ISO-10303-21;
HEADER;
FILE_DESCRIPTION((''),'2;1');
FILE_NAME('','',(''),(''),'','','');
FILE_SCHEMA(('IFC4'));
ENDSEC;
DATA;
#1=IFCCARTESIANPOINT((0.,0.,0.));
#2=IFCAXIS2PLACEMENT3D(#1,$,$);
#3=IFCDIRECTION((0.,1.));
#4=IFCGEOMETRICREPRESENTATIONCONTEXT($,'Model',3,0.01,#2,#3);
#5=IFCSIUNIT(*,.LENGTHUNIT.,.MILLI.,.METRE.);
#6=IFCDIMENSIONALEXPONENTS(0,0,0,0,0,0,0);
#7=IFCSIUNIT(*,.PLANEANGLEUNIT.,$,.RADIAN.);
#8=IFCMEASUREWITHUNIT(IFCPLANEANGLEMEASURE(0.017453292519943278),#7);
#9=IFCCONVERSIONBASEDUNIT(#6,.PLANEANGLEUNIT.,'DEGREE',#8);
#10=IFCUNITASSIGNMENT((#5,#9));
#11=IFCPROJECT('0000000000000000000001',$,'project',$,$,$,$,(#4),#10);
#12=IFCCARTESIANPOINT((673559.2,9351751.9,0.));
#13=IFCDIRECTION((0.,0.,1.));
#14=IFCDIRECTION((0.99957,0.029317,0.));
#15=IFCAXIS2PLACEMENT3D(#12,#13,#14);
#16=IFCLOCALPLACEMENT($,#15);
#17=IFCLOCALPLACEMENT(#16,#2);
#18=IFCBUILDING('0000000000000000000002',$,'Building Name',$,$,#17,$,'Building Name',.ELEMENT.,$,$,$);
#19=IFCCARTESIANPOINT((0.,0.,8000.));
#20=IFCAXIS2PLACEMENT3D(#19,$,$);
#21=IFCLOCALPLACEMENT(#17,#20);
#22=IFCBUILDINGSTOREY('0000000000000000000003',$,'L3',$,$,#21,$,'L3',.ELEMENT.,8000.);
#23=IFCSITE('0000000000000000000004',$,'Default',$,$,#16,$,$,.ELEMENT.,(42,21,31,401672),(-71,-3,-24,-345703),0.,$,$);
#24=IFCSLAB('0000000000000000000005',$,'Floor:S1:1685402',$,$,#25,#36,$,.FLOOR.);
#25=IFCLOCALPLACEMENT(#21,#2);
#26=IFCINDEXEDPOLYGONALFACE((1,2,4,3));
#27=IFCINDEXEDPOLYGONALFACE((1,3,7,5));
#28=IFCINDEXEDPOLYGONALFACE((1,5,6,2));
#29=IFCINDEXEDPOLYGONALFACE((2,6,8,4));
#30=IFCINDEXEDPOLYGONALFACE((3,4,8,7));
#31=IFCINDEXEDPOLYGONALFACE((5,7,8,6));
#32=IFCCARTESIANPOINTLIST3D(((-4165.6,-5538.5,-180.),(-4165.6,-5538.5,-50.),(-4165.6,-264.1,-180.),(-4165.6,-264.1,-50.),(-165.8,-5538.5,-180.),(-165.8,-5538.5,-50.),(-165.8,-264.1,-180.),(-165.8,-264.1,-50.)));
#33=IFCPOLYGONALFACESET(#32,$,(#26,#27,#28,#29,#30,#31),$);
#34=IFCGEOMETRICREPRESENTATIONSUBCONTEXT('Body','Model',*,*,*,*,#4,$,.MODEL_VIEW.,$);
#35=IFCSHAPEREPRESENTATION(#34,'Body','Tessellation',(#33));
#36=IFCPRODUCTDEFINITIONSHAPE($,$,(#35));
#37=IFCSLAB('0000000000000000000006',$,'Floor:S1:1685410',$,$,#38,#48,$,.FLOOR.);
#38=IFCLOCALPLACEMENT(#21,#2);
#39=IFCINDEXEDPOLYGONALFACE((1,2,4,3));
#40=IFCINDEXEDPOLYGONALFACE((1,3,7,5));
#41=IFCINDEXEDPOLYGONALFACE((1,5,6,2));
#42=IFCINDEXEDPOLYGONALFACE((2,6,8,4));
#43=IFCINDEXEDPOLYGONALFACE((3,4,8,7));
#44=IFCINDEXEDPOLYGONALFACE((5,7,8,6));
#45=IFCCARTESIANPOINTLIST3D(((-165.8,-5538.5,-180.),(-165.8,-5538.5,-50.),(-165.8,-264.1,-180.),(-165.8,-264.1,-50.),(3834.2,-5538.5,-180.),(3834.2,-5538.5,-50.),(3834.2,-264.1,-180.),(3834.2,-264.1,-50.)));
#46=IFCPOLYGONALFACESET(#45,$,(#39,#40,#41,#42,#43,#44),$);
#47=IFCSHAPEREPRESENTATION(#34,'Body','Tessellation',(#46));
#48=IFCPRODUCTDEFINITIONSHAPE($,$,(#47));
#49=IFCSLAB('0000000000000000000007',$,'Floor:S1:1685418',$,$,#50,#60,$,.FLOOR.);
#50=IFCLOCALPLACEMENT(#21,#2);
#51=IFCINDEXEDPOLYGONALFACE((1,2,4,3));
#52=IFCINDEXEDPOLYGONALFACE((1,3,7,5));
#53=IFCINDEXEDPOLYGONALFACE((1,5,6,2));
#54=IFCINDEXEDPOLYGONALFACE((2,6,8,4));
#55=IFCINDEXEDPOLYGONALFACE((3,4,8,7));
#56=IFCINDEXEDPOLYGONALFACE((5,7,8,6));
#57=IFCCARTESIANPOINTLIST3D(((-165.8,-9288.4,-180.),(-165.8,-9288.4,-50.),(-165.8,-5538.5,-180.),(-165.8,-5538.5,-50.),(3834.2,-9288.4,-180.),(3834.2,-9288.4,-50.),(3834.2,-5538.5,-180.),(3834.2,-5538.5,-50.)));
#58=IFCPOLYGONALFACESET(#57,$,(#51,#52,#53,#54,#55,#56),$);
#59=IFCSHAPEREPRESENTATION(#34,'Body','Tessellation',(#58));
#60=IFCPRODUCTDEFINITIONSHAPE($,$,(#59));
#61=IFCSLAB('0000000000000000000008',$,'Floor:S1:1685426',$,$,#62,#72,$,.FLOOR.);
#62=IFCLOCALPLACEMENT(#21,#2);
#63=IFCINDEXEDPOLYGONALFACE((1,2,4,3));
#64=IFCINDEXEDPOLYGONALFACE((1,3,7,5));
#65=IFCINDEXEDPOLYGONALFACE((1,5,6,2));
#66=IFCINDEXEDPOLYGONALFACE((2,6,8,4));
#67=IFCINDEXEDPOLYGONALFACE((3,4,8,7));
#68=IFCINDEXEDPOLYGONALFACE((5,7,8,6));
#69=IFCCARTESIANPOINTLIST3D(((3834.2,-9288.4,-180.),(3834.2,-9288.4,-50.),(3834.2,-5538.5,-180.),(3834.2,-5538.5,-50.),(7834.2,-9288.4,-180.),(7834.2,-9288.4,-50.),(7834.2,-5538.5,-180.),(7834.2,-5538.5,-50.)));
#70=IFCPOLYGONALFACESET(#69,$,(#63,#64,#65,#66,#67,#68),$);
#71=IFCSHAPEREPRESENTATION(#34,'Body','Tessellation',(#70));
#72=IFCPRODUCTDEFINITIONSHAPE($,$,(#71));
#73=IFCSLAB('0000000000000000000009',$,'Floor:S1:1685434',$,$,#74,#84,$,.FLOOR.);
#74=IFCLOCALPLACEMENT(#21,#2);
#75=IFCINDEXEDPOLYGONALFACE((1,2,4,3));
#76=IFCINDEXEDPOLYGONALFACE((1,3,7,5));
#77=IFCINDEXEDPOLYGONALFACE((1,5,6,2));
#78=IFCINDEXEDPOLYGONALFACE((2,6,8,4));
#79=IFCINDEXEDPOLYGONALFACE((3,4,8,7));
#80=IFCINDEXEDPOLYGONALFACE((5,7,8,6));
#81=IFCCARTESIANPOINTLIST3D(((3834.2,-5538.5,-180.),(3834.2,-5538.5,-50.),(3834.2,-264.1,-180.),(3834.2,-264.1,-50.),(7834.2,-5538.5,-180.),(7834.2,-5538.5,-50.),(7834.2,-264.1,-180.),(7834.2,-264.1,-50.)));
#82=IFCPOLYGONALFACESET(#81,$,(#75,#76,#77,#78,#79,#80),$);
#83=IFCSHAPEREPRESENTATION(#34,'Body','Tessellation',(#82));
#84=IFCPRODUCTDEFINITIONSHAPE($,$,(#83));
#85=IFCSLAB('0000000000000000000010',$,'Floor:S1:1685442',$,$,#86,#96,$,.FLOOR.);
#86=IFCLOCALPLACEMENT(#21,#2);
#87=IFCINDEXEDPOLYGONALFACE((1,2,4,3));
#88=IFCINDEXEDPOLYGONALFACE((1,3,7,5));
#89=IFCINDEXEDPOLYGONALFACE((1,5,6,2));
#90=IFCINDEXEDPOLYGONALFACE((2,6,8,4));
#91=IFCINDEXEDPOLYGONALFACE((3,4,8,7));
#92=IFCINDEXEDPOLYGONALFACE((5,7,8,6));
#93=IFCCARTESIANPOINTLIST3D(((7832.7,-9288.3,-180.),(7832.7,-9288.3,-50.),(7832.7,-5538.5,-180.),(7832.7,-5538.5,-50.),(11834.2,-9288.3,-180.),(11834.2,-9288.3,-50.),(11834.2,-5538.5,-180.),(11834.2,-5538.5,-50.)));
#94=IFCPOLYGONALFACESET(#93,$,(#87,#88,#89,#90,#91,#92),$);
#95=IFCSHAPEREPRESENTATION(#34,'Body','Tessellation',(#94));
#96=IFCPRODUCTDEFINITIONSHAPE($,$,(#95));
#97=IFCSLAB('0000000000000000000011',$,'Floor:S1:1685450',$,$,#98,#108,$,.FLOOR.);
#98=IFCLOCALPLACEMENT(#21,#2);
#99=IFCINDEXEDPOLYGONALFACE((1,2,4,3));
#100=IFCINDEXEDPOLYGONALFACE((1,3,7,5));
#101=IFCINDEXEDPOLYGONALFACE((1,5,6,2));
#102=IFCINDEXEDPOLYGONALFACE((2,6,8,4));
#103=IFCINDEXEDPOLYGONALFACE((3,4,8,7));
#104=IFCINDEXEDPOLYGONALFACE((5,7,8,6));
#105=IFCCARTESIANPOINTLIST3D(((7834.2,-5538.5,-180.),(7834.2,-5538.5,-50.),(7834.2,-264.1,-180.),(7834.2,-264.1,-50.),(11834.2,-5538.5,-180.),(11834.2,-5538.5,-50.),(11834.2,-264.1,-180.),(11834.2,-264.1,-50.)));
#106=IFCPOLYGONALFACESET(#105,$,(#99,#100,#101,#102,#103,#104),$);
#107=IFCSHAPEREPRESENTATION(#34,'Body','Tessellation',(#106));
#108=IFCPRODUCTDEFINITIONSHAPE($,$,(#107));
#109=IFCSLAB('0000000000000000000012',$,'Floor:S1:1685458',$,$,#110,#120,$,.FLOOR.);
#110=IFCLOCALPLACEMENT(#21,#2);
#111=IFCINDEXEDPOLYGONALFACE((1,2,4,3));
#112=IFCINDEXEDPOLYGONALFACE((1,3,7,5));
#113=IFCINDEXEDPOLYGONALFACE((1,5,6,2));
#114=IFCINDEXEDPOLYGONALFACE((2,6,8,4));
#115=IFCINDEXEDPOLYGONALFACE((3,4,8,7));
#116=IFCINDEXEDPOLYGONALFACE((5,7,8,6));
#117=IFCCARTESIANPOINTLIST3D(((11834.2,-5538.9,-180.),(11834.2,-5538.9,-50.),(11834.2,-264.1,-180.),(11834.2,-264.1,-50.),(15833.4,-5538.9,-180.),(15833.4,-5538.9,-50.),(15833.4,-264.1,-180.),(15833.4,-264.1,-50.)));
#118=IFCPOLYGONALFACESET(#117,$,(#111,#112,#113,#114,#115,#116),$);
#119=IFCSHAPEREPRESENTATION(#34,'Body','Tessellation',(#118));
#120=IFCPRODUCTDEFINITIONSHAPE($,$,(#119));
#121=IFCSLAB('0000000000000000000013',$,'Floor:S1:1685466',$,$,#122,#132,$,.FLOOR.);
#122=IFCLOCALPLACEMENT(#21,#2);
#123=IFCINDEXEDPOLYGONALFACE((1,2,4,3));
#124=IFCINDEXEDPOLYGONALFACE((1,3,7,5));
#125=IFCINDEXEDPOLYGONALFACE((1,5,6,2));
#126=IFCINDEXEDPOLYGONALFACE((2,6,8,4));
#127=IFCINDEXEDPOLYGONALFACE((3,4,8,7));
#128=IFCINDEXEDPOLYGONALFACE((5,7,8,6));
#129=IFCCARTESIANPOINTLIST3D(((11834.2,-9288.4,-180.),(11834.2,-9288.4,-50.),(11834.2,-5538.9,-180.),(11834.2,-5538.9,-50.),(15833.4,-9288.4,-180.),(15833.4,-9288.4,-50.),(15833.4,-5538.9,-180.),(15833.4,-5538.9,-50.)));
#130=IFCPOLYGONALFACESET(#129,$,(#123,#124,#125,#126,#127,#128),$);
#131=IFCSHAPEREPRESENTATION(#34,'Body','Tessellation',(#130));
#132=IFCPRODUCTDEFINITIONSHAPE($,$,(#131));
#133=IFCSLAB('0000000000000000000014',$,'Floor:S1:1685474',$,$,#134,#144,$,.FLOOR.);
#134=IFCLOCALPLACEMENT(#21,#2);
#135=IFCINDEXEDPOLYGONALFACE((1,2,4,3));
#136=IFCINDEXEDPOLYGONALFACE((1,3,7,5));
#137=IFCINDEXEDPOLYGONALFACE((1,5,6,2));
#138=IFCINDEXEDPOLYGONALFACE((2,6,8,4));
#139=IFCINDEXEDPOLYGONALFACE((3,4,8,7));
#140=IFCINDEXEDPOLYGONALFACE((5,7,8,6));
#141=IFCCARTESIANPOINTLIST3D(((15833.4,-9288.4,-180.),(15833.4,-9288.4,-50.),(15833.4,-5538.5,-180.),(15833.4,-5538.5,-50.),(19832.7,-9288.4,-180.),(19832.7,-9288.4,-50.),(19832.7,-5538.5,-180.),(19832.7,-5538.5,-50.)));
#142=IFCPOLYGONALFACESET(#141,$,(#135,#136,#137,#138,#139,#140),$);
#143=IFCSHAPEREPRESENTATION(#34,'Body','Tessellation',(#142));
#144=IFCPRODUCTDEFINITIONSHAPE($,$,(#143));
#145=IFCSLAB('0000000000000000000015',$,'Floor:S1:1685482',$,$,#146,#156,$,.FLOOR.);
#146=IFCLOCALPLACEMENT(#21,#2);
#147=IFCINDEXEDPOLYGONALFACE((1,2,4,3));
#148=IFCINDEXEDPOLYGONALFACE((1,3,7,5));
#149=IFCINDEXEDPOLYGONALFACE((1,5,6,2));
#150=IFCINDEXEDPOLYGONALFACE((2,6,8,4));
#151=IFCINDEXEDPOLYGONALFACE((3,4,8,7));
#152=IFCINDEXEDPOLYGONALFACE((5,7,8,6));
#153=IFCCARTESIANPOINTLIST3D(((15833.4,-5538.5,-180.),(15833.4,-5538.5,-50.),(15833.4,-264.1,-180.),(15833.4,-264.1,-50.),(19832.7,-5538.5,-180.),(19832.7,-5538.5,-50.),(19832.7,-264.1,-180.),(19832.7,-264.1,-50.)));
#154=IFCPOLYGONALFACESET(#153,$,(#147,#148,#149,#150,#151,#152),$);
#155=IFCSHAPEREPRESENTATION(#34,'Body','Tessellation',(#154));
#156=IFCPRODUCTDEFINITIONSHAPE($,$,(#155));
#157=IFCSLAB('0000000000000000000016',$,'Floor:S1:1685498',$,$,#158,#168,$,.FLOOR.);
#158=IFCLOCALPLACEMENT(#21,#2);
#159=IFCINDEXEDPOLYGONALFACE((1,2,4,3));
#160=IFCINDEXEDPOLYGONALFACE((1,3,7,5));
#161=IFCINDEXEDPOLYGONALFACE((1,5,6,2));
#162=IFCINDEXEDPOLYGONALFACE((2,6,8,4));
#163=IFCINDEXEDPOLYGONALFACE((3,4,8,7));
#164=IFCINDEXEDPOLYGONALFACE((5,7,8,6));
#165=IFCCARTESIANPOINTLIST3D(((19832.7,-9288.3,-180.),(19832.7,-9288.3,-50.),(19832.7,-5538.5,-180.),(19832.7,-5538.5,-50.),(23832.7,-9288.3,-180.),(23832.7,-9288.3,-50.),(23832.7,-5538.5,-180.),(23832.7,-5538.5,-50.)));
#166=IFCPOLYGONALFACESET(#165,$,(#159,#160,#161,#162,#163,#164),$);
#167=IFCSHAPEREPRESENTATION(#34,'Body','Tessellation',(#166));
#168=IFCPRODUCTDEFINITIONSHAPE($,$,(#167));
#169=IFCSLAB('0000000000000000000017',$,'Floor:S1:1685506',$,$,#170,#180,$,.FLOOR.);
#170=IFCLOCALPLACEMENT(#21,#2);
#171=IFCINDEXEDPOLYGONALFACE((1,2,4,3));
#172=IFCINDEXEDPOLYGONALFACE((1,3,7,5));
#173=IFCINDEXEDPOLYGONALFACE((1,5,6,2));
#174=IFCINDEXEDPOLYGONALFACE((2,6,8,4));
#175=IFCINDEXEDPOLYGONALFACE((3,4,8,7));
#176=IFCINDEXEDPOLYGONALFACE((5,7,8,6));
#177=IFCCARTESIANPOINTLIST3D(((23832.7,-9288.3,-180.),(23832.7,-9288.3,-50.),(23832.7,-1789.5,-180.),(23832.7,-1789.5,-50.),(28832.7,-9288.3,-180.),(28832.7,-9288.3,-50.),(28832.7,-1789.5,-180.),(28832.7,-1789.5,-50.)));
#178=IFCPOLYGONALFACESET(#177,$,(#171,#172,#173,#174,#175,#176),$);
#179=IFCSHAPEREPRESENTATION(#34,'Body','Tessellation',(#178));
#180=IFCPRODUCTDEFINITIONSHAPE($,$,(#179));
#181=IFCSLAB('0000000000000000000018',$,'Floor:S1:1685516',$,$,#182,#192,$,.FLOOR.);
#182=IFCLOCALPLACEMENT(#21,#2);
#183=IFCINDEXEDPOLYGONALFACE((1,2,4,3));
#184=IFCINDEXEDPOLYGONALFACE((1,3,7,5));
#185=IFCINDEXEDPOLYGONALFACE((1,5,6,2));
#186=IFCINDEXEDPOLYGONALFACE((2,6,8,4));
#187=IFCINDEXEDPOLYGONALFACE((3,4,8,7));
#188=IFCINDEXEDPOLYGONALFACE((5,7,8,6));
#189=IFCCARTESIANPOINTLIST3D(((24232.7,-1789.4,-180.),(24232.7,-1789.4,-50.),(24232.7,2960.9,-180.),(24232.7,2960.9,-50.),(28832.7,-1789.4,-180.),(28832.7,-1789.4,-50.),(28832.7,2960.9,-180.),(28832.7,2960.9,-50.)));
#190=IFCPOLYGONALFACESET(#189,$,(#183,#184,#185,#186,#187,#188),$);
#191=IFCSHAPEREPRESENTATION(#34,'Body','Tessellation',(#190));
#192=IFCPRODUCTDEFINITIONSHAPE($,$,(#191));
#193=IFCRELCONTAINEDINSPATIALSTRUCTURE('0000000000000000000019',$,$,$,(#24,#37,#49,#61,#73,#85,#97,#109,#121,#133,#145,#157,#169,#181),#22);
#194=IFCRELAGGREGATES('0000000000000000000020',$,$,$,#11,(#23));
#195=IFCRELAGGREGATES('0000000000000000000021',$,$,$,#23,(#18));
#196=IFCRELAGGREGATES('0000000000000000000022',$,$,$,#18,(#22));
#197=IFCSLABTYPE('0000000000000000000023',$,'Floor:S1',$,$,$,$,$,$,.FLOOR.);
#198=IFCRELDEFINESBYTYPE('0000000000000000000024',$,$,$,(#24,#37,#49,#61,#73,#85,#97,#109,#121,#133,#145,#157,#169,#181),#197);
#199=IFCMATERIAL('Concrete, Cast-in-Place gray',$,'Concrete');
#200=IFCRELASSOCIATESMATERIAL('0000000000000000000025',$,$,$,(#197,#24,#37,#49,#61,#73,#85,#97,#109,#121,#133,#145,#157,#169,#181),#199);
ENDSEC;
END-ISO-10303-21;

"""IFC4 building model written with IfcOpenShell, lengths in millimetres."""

from ifc_helpers import new_model, entity, si_unit, converted_unit, direction, frame, origin, place, context, subcontext, project, spatial, indexed_curve, outline, extrude, material, type_object, element, save


model = new_model("IFC4")

# Units and contexts
model_context = context("Model", 3, precision=0.01, world=origin(), true_north=direction((0.0, 1.0)))
body_context = subcontext(model_context, "Body", "Model", "MODEL_VIEW")
ifc_project = project(units=[si_unit("LENGTHUNIT", "METRE", prefix="MILLI"), converted_unit("PLANEANGLEUNIT", "DEGREE", entity("IfcPlaneAngleMeasure", 0.017453292519943278), si_unit("PLANEANGLEUNIT", "RADIAN"), dimensions=[0, 0, 0, 0, 0, 0, 0])], contexts=[model_context])

# Site, building, storey
site_placement = place(None, frame((673559.2, 9351751.9, 0.0), z_axis=(0.0, 0.0, 1.0), x_axis=(0.99957, 0.029317, 0.0)))
site = spatial("IfcSite", under=ifc_project, at=site_placement, Name="Default", CompositionType="ELEMENT", RefLatitude=(42, 21, 31, 401672), RefLongitude=(-71, -3, -24, -345703), RefElevation=0.0)
building_placement = place(site_placement, origin())
building = spatial("IfcBuilding", under=site, at=building_placement, Name="Building Name", LongName="Building Name", CompositionType="ELEMENT")
storey_placement = place(building_placement, frame((0.0, 0.0, 8000.0)))
storey = spatial("IfcBuildingStorey", under=building, at=storey_placement, Name="L3", LongName="L3", CompositionType="ELEMENT", Elevation=8000.0)

# Shared definitions
ifc_material = material(Name="Concrete, Cast-in-Place gray", Category="Concrete")

# Slabs
slab_type_1 = type_object("IfcSlabType", Name="Floor:S1", PredefinedType="FLOOR", material=ifc_material)
slab_1_placement = place(storey_placement, origin())
element("IfcSlab", 1, at=slab_1_placement, inside=storey, type_object=slab_type_1, material=ifc_material, Name="Floor:S1:1685402", PredefinedType="FLOOR", context=body_context, shape_type="SweptSolid", body=[
    extrude(outline(indexed_curve([(-2637.2, -1999.9), (2637.2, -1999.9), (2637.2, 1999.9), (-2637.2, 1999.9), (-2637.2, -1999.9)], self_intersect=False)), frame((-2165.7, -2901.3, -50.0), z_axis=(0.0, 0.0, -1.0), x_axis=(0.0, 1.0, 0.0)), (0.0, 0.0, 1.0), 130.0),
])
slab_2_placement = place(storey_placement, origin())
element("IfcSlab", 2, at=slab_2_placement, inside=storey, type_object=slab_type_1, material=ifc_material, Name="Floor:S1:1685410", PredefinedType="FLOOR", context=body_context, shape_type="SweptSolid", body=[
    extrude(outline(indexed_curve([(-2637.2, -2000.0), (2637.2, -2000.0), (2637.2, 2000.0), (-2637.2, 2000.0), (-2637.2, -2000.0)], self_intersect=False)), frame((1834.2, -2901.3, -50.0), z_axis=(0.0, 0.0, -1.0), x_axis=(0.0, 1.0, 0.0)), (0.0, 0.0, 1.0), 130.0),
])
slab_3_placement = place(storey_placement, origin())
element("IfcSlab", 3, at=slab_3_placement, inside=storey, type_object=slab_type_1, material=ifc_material, Name="Floor:S1:1685418", PredefinedType="FLOOR", context=body_context, shape_type="SweptSolid", body=[
    extrude(outline(indexed_curve([(-1874.9, -2000.0), (1874.9, -2000.0), (1874.9, 2000.0), (-1874.9, 2000.0), (-1874.9, -2000.0)], self_intersect=False)), frame((1834.2, -7413.5, -50.0), z_axis=(0.0, 0.0, -1.0), x_axis=(0.0, 1.0, 0.0)), (0.0, 0.0, 1.0), 130.0),
])
slab_4_placement = place(storey_placement, origin())
element("IfcSlab", 4, at=slab_4_placement, inside=storey, type_object=slab_type_1, material=ifc_material, Name="Floor:S1:1685426", PredefinedType="FLOOR", context=body_context, shape_type="SweptSolid", body=[
    extrude(outline(indexed_curve([(-1874.9, -2000.0), (1874.9, -2000.0), (1874.9, 2000.0), (-1874.9, 2000.0), (-1874.9, -2000.0)], self_intersect=False)), frame((5834.2, -7413.5, -50.0), z_axis=(0.0, 0.0, -1.0), x_axis=(0.0, 1.0, 0.0)), (0.0, 0.0, 1.0), 130.0),
])
slab_5_placement = place(storey_placement, origin())
element("IfcSlab", 5, at=slab_5_placement, inside=storey, type_object=slab_type_1, material=ifc_material, Name="Floor:S1:1685434", PredefinedType="FLOOR", context=body_context, shape_type="SweptSolid", body=[
    extrude(outline(indexed_curve([(-2637.2, -2000.0), (2637.2, -2000.0), (2637.2, 2000.0), (-2637.2, 2000.0), (-2637.2, -2000.0)], self_intersect=False)), frame((5834.2, -2901.3, -50.0), z_axis=(0.0, 0.0, -1.0), x_axis=(0.0, 1.0, 0.0)), (0.0, 0.0, 1.0), 130.0),
])
slab_6_placement = place(storey_placement, origin())
element("IfcSlab", 6, at=slab_6_placement, inside=storey, type_object=slab_type_1, material=ifc_material, Name="Floor:S1:1685442", PredefinedType="FLOOR", context=body_context, shape_type="SweptSolid", body=[
    extrude(outline(indexed_curve([(-1874.9, -2000.7), (1874.9, -2000.7), (1874.9, 2000.7), (-1874.9, 2000.7), (-1874.9, -2000.7)], self_intersect=False)), frame((9833.4, -7413.4, -50.0), z_axis=(0.0, 0.0, -1.0), x_axis=(0.0, 1.0, 0.0)), (0.0, 0.0, 1.0), 130.0),
])
slab_7_placement = place(storey_placement, origin())
element("IfcSlab", 7, at=slab_7_placement, inside=storey, type_object=slab_type_1, material=ifc_material, Name="Floor:S1:1685450", PredefinedType="FLOOR", context=body_context, shape_type="SweptSolid", body=[
    extrude(outline(indexed_curve([(-2637.2, -2000.0), (2637.2, -2000.0), (2637.2, 2000.0), (-2637.2, 2000.0), (-2637.2, -2000.0)], self_intersect=False)), frame((9834.2, -2901.3, -50.0), z_axis=(0.0, 0.0, -1.0), x_axis=(0.0, 1.0, 0.0)), (0.0, 0.0, 1.0), 130.0),
])
slab_8_placement = place(storey_placement, origin())
element("IfcSlab", 8, at=slab_8_placement, inside=storey, type_object=slab_type_1, material=ifc_material, Name="Floor:S1:1685458", PredefinedType="FLOOR", context=body_context, shape_type="SweptSolid", body=[
    extrude(outline(indexed_curve([(-2637.4, -1999.6), (2637.4, -1999.6), (2637.4, 1999.6), (-2637.4, 1999.6), (-2637.4, -1999.6)], self_intersect=False)), frame((13833.8, -2901.5, -50.0), z_axis=(0.0, 0.0, -1.0), x_axis=(0.0, 1.0, 0.0)), (0.0, 0.0, 1.0), 130.0),
])
slab_9_placement = place(storey_placement, origin())
element("IfcSlab", 9, at=slab_9_placement, inside=storey, type_object=slab_type_1, material=ifc_material, Name="Floor:S1:1685466", PredefinedType="FLOOR", context=body_context, shape_type="SweptSolid", body=[
    extrude(outline(indexed_curve([(-1874.7, -1999.6), (1874.7, -1999.6), (1874.7, 1999.6), (-1874.7, 1999.6), (-1874.7, -1999.6)], self_intersect=False)), frame((13833.8, -7413.6, -50.0), z_axis=(0.0, 0.0, -1.0), x_axis=(0.0, 1.0, 0.0)), (0.0, 0.0, 1.0), 130.0),
])
slab_10_placement = place(storey_placement, origin())
element("IfcSlab", 10, at=slab_10_placement, inside=storey, type_object=slab_type_1, material=ifc_material, Name="Floor:S1:1685474", PredefinedType="FLOOR", context=body_context, shape_type="SweptSolid", body=[
    extrude(outline(indexed_curve([(-1874.9, -1999.6), (1874.9, -1999.6), (1874.9, 1999.6), (-1874.9, 1999.6), (-1874.9, -1999.6)], self_intersect=False)), frame((17833.0, -7413.5, -50.0), z_axis=(0.0, 0.0, -1.0), x_axis=(0.0, 1.0, 0.0)), (0.0, 0.0, 1.0), 130.0),
])
slab_11_placement = place(storey_placement, origin())
element("IfcSlab", 11, at=slab_11_placement, inside=storey, type_object=slab_type_1, material=ifc_material, Name="Floor:S1:1685482", PredefinedType="FLOOR", context=body_context, shape_type="SweptSolid", body=[
    extrude(outline(indexed_curve([(-2637.2, -1999.6), (2637.2, -1999.6), (2637.2, 1999.6), (-2637.2, 1999.6), (-2637.2, -1999.6)], self_intersect=False)), frame((17833.0, -2901.3, -50.0), z_axis=(0.0, 0.0, -1.0), x_axis=(0.0, 1.0, 0.0)), (0.0, 0.0, 1.0), 130.0),
])
slab_12_placement = place(storey_placement, origin())
element("IfcSlab", 12, at=slab_12_placement, inside=storey, type_object=slab_type_1, material=ifc_material, Name="Floor:S1:1685498", PredefinedType="FLOOR", context=body_context, shape_type="SweptSolid", body=[
    extrude(outline(indexed_curve([(-1874.9, -2000.0), (1874.9, -2000.0), (1874.9, 2000.0), (-1874.9, 2000.0), (-1874.9, -2000.0)], self_intersect=False)), frame((21832.7, -7413.4, -50.0), z_axis=(0.0, 0.0, -1.0), x_axis=(0.0, 1.0, 0.0)), (0.0, 0.0, 1.0), 130.0),
])
slab_13_placement = place(storey_placement, origin())
element("IfcSlab", 13, at=slab_13_placement, inside=storey, type_object=slab_type_1, material=ifc_material, Name="Floor:S1:1685506", PredefinedType="FLOOR", context=body_context, shape_type="SweptSolid", body=[
    extrude(outline(indexed_curve([(-3749.4, -2500.0), (3749.4, -2500.0), (3749.4, 2500.0), (-3749.4, 2500.0), (-3749.4, -2500.0)], self_intersect=False)), frame((26332.7, -5538.9, -50.0), z_axis=(0.0, 0.0, -1.0), x_axis=(0.0, 1.0, 0.0)), (0.0, 0.0, 1.0), 130.0),
])
slab_14_placement = place(storey_placement, origin())
element("IfcSlab", 14, at=slab_14_placement, inside=storey, type_object=slab_type_1, material=ifc_material, Name="Floor:S1:1685516", PredefinedType="FLOOR", context=body_context, shape_type="SweptSolid", body=[
    extrude(outline(indexed_curve([(-2375.2, -2300.0), (2375.2, -2300.0), (2375.2, 2300.0), (-2375.2, 2300.0), (-2375.2, -2300.0)], self_intersect=False)), frame((26532.7, 585.8, -50.0), z_axis=(0.0, 0.0, -1.0), x_axis=(0.0, 1.0, 0.0)), (0.0, 0.0, 1.0), 130.0),
])

save(model, "model.ifc")
